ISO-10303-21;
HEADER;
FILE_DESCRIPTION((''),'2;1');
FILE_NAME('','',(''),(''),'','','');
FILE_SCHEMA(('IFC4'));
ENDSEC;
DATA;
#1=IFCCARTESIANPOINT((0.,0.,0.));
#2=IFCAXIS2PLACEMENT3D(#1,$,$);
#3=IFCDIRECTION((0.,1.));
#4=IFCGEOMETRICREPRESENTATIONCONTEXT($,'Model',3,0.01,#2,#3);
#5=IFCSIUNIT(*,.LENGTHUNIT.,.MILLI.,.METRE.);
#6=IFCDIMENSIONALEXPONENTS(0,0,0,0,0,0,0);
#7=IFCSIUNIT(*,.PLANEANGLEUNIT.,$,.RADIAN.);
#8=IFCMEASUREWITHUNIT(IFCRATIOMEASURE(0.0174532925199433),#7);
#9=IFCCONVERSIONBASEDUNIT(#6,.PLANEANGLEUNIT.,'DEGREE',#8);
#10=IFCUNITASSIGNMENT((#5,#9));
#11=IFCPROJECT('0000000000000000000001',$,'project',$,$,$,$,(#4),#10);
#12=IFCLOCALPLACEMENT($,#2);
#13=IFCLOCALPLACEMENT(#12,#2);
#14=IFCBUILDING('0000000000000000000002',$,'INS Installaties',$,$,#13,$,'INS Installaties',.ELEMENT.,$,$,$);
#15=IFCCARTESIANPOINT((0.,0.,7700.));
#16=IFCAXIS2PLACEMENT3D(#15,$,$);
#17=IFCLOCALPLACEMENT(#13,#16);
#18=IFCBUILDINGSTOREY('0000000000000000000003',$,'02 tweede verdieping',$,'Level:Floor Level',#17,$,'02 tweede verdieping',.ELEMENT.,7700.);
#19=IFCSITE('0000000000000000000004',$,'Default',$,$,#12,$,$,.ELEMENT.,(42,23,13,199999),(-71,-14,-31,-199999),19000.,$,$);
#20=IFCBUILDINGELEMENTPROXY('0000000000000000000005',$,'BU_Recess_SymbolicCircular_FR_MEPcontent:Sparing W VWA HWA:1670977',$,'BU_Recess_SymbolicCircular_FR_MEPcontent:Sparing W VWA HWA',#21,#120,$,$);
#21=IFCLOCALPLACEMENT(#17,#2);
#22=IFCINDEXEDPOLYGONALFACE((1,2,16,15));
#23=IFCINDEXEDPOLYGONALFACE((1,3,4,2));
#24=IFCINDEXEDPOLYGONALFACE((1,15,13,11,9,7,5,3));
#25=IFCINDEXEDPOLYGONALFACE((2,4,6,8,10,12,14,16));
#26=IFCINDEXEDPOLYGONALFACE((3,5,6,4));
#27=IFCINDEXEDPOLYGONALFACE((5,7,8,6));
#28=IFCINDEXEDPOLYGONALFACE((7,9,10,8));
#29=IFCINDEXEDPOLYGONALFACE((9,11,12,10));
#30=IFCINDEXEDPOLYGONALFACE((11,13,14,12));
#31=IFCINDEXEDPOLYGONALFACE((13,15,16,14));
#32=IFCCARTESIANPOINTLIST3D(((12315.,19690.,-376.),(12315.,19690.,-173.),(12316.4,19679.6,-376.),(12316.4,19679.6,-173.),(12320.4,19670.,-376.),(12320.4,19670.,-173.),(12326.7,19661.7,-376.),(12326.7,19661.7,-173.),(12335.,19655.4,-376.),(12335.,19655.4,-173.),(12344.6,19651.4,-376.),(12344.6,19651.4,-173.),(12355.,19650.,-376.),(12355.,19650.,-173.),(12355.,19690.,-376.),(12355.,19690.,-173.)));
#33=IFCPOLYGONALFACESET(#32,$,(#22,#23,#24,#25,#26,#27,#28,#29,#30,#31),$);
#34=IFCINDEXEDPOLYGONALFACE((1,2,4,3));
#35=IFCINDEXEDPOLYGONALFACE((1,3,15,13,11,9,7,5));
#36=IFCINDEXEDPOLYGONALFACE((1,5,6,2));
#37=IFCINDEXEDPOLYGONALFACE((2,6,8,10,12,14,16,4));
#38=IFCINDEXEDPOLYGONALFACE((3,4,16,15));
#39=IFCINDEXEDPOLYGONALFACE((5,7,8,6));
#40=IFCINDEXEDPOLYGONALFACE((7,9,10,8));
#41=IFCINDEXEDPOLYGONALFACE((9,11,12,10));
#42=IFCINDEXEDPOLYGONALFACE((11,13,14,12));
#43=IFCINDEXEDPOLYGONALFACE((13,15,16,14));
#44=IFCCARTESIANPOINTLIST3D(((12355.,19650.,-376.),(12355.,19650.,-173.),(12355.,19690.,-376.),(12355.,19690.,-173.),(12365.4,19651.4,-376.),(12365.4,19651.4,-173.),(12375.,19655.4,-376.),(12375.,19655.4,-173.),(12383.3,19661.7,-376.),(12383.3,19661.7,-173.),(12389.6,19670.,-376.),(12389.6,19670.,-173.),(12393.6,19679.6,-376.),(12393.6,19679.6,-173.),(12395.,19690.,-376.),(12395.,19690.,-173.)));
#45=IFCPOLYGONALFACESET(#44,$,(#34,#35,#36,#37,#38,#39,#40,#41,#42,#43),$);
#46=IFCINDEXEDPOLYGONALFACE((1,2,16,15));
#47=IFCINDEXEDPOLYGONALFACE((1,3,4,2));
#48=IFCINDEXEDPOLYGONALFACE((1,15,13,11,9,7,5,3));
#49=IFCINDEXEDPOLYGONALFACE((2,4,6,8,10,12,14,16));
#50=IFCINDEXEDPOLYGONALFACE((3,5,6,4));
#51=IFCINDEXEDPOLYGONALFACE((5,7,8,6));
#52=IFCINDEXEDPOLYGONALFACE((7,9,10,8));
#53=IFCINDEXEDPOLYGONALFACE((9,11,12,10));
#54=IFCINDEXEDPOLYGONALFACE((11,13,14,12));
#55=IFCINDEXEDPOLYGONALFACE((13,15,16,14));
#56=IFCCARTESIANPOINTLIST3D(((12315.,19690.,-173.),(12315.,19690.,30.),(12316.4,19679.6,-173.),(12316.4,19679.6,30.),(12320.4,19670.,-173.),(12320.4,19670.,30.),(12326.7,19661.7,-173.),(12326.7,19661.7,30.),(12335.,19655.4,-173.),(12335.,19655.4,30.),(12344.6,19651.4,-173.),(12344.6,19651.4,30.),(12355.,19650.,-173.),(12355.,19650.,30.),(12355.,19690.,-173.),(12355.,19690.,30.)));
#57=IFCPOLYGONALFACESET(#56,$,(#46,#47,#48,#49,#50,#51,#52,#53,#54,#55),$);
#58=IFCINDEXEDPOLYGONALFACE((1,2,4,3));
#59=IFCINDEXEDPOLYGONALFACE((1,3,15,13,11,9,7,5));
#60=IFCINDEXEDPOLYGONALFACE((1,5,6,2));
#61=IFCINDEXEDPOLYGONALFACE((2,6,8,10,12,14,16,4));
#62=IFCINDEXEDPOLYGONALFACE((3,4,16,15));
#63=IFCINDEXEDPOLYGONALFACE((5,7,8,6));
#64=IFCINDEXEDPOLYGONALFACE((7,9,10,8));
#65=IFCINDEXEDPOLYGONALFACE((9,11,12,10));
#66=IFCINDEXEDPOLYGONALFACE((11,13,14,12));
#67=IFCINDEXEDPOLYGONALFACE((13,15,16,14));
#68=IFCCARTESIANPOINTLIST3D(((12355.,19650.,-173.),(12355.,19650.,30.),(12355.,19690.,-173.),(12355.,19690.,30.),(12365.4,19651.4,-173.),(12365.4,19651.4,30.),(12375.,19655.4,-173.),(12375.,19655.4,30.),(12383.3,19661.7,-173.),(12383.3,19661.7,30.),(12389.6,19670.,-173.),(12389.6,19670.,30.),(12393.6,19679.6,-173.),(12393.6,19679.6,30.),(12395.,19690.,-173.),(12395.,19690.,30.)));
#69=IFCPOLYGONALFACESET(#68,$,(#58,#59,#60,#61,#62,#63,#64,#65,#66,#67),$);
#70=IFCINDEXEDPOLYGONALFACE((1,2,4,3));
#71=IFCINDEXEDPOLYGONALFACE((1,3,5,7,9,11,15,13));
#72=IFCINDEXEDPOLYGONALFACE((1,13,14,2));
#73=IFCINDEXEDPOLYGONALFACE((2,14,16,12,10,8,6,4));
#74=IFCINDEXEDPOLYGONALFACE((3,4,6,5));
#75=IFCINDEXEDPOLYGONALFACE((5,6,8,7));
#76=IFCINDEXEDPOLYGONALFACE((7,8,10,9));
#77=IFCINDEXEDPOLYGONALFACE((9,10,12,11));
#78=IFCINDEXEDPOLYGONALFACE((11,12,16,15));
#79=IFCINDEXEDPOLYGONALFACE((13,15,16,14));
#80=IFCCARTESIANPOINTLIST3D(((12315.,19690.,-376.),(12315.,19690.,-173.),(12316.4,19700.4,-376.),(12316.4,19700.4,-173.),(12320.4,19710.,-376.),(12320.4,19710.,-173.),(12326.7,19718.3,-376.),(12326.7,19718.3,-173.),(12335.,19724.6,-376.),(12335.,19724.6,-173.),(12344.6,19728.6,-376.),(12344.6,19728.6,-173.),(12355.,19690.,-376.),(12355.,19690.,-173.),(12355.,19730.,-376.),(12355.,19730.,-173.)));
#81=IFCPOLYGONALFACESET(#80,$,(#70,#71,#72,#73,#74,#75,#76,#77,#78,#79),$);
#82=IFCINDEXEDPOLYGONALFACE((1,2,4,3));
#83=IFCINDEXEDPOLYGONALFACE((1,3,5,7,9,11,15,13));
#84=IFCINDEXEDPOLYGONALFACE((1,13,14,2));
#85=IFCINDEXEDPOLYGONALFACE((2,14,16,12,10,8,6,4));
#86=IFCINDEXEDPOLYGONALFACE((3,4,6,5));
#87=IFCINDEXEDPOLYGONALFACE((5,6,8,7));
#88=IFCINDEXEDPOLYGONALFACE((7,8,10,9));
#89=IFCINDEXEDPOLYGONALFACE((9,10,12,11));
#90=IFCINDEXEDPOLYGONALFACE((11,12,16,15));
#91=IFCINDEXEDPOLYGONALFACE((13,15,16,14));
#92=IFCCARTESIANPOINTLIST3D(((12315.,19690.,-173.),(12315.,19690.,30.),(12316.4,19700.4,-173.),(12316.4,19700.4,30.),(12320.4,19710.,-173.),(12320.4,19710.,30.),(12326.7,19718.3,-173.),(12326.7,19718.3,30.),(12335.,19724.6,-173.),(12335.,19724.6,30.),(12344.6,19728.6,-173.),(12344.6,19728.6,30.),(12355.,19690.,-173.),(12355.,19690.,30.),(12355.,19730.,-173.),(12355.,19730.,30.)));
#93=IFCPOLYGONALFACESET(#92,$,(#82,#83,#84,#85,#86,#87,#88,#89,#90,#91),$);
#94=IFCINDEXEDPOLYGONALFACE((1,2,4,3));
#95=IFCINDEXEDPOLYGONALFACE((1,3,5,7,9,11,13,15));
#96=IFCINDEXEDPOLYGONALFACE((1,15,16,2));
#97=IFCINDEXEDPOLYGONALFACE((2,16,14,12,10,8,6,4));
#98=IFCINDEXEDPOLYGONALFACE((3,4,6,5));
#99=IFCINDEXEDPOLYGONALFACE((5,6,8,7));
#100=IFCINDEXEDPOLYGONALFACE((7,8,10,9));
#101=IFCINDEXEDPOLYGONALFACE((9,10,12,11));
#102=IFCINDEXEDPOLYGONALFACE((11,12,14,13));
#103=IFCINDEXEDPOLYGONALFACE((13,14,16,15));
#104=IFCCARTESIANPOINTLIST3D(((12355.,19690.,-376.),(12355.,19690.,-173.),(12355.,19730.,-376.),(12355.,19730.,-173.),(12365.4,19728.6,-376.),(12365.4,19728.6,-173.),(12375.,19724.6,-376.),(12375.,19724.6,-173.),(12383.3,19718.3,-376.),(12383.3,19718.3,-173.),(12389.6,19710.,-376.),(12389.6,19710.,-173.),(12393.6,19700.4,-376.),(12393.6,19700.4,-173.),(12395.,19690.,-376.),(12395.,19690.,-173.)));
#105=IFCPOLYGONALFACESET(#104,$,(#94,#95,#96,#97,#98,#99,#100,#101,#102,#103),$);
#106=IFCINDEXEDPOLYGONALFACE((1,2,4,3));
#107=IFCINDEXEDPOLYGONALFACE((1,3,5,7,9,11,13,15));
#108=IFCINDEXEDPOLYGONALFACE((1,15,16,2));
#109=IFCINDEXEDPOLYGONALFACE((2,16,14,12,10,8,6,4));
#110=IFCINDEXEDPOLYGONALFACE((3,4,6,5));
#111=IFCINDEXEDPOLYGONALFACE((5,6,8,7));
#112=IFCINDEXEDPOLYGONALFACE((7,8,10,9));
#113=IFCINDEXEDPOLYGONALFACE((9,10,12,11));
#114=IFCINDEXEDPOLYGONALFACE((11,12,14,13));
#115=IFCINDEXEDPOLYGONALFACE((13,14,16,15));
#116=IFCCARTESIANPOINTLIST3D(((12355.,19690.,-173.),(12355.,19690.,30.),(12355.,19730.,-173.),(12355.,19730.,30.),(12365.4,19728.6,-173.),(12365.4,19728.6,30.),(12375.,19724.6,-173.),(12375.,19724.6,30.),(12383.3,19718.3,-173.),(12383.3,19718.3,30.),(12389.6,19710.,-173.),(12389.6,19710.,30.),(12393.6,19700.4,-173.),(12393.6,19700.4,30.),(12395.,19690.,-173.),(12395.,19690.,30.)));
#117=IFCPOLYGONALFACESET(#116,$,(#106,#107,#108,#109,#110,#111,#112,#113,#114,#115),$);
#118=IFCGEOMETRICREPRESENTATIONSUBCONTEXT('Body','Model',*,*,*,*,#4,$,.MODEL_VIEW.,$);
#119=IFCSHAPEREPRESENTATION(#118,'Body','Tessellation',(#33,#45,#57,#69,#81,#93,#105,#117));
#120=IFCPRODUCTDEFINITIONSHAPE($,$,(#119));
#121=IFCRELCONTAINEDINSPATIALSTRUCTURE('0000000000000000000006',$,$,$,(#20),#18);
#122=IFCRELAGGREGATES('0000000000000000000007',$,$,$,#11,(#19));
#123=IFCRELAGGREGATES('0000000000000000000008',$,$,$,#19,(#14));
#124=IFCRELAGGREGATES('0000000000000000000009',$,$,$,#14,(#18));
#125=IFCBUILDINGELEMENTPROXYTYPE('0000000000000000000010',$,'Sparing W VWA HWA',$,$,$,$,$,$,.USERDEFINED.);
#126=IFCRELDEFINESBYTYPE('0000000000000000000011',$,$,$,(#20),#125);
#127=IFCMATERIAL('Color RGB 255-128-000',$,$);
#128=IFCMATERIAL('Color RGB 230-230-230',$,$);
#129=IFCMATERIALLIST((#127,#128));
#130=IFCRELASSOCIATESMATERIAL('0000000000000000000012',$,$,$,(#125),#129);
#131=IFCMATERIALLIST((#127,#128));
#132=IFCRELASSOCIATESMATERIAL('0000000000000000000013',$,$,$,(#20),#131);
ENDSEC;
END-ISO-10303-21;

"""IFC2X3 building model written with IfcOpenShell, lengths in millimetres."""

from ifc_helpers import new_model, entity, si_unit, converted_unit, direction, frame, frame_2d, origin, place, context, subcontext, project, spatial, polyline, circle_curve, parameter, trimmed, segment, composite_curve, outline, extrude, source, transform, mapped, material, material_list, type_object, type_shapes, element, save


model = new_model("IFC2X3")

# Units and contexts
model_context = context("Model", 3, precision=0.01, world=origin(), true_north=direction((0.0, 1.0)))
body_context = subcontext(model_context, "Body", "Model", "MODEL_VIEW")
ifc_project = project(units=[si_unit("LENGTHUNIT", "METRE", prefix="MILLI"), converted_unit("PLANEANGLEUNIT", "DEGREE", entity("IfcRatioMeasure", 0.0174532925199433), si_unit("PLANEANGLEUNIT", "RADIAN"), dimensions=[0, 0, 0, 0, 0, 0, 0])], contexts=[model_context])

# Site, building, storey
site_placement = place(None, origin())
site = spatial("IfcSite", under=ifc_project, at=site_placement, Name="Default", CompositionType="ELEMENT", RefLatitude=(42, 23, 13, 199999), RefLongitude=(-71, -14, -31, -199999), RefElevation=19000.0)
building_placement = place(site_placement, origin())
building = spatial("IfcBuilding", under=site, at=building_placement, Name="INS Installaties", LongName="INS Installaties", CompositionType="ELEMENT")
storey_placement = place(building_placement, frame((0.0, 0.0, 7700.0)))
storey = spatial("IfcBuildingStorey", under=building, at=storey_placement, Name="02 tweede verdieping", ObjectType="Level:Floor Level", LongName="02 tweede verdieping", CompositionType="ELEMENT", Elevation=7700.0)

# Building element proxy
ifc_material_1 = material(Name="Color RGB 255-128-000")
ifc_material_2 = material(Name="Color RGB 230-230-230")
ifc_material_list_1 = material_list([ifc_material_1, ifc_material_2])
ifc_material_list_2 = material_list([ifc_material_1, ifc_material_2])
building_element_proxy_type_1 = type_object("IfcBuildingElementProxyType", Name="Sparing W VWA HWA", PredefinedType="USERDEFINED", material=ifc_material_list_2)
shared_shape_1 = source(origin(), body_context, "Body", "SweptSolid", [
    extrude(outline(composite_curve([segment(trimmed(circle_curve(frame_2d((13.3, 13.3), x_axis=(1.0, 0.0)), 40.0), [parameter(180.0)], [parameter(270.0)], True, "PARAMETER"), True, "CONTINUOUS"), segment(polyline([(13.3, -26.7), (13.3, 13.3)]), True, "CONTINUOUS"), segment(polyline([(13.3, 13.3), (-26.7, 13.3)]), True, "CONTINUOUS")], self_intersect=False)), frame((13.3, 13.3, -403.0), z_axis=(0.0, 0.0, 1.0), x_axis=(-1.0, 0.0, 0.0)), (0.0, 0.0, 1.0), 203.0),
    extrude(outline(composite_curve([segment(polyline([(-26.7, -13.3), (13.3, -13.3)]), True, "CONTINUOUS"), segment(polyline([(13.3, -13.3), (13.3, 26.7)]), True, "CONTINUOUS"), segment(trimmed(circle_curve(frame_2d((13.3, -13.3), x_axis=(1.0, 0.0)), 40.0), [parameter(90.0)], [parameter(180.0)], True, "PARAMETER"), True, "CONTINUOUS")], self_intersect=False)), frame((-13.3, 13.3, -403.0)), (0.0, 0.0, 1.0), 203.0),
    extrude(outline(composite_curve([segment(trimmed(circle_curve(frame_2d((13.3, 13.3), x_axis=(1.0, 0.0)), 40.0), [parameter(180.0)], [parameter(270.0)], True, "PARAMETER"), True, "CONTINUOUS"), segment(polyline([(13.3, -26.7), (13.3, 13.3)]), True, "CONTINUOUS"), segment(polyline([(13.3, 13.3), (-26.7, 13.3)]), True, "CONTINUOUS")], self_intersect=False)), frame((13.3, 13.3, -200.0), z_axis=(0.0, 0.0, 1.0), x_axis=(-1.0, 0.0, 0.0)), (0.0, 0.0, 1.0), 203.0),
    extrude(outline(composite_curve([segment(polyline([(-26.7, -13.3), (13.3, -13.3)]), True, "CONTINUOUS"), segment(polyline([(13.3, -13.3), (13.3, 26.7)]), True, "CONTINUOUS"), segment(trimmed(circle_curve(frame_2d((13.3, -13.3), x_axis=(1.0, 0.0)), 40.0), [parameter(90.0)], [parameter(180.0)], True, "PARAMETER"), True, "CONTINUOUS")], self_intersect=False)), frame((-13.3, 13.3, -200.0)), (0.0, 0.0, 1.0), 203.0),
    extrude(outline(composite_curve([segment(polyline([(-26.7, -13.3), (13.3, -13.3)]), True, "CONTINUOUS"), segment(polyline([(13.3, -13.3), (13.3, 26.7)]), True, "CONTINUOUS"), segment(trimmed(circle_curve(frame_2d((13.3, -13.3), x_axis=(1.0, 0.0)), 40.0), [parameter(90.0)], [parameter(180.0)], True, "PARAMETER"), True, "CONTINUOUS")], self_intersect=False)), frame((13.3, -13.3, -403.0), z_axis=(0.0, 0.0, 1.0), x_axis=(-1.0, 0.0, 0.0)), (0.0, 0.0, 1.0), 203.0),
    extrude(outline(composite_curve([segment(polyline([(-26.7, -13.3), (13.3, -13.3)]), True, "CONTINUOUS"), segment(polyline([(13.3, -13.3), (13.3, 26.7)]), True, "CONTINUOUS"), segment(trimmed(circle_curve(frame_2d((13.3, -13.3), x_axis=(1.0, 0.0)), 40.0), [parameter(90.0)], [parameter(180.0)], True, "PARAMETER"), True, "CONTINUOUS")], self_intersect=False)), frame((13.3, -13.3, -200.0), z_axis=(0.0, 0.0, 1.0), x_axis=(-1.0, 0.0, 0.0)), (0.0, 0.0, 1.0), 203.0),
    extrude(outline(composite_curve([segment(trimmed(circle_curve(frame_2d((13.3, 13.3), x_axis=(1.0, 0.0)), 40.0), [parameter(180.0)], [parameter(270.0)], True, "PARAMETER"), True, "CONTINUOUS"), segment(polyline([(13.3, -26.7), (13.3, 13.3)]), True, "CONTINUOUS"), segment(polyline([(13.3, 13.3), (-26.7, 13.3)]), True, "CONTINUOUS")], self_intersect=False)), frame((-13.3, -13.3, -403.0)), (0.0, 0.0, 1.0), 203.0),
    extrude(outline(composite_curve([segment(trimmed(circle_curve(frame_2d((13.3, 13.3), x_axis=(1.0, 0.0)), 40.0), [parameter(180.0)], [parameter(270.0)], True, "PARAMETER"), True, "CONTINUOUS"), segment(polyline([(13.3, -26.7), (13.3, 13.3)]), True, "CONTINUOUS"), segment(polyline([(13.3, 13.3), (-26.7, 13.3)]), True, "CONTINUOUS")], self_intersect=False)), frame((-13.3, -13.3, -200.0)), (0.0, 0.0, 1.0), 203.0),
])
type_shapes(building_element_proxy_type_1, [shared_shape_1])
proxy_1_placement = place(storey_placement, frame((12355.0, 19690.0, 27.0), z_axis=(0.0, 0.0, 1.0), x_axis=(-1.0, 0.0, 0.0)))
element("IfcBuildingElementProxy", 1, at=proxy_1_placement, inside=storey, type_object=building_element_proxy_type_1, material=ifc_material_list_1, Name="BU_Recess_SymbolicCircular_FR_MEPcontent:Sparing W VWA HWA:1670977", ObjectType="BU_Recess_SymbolicCircular_FR_MEPcontent:Sparing W VWA HWA", context=body_context, shape_type="MappedRepresentation", body=[
    mapped(shared_shape_1, transform((0.0, 0.0, 0.0), scale=1.0)),
])

save(model, "model.ifc")
